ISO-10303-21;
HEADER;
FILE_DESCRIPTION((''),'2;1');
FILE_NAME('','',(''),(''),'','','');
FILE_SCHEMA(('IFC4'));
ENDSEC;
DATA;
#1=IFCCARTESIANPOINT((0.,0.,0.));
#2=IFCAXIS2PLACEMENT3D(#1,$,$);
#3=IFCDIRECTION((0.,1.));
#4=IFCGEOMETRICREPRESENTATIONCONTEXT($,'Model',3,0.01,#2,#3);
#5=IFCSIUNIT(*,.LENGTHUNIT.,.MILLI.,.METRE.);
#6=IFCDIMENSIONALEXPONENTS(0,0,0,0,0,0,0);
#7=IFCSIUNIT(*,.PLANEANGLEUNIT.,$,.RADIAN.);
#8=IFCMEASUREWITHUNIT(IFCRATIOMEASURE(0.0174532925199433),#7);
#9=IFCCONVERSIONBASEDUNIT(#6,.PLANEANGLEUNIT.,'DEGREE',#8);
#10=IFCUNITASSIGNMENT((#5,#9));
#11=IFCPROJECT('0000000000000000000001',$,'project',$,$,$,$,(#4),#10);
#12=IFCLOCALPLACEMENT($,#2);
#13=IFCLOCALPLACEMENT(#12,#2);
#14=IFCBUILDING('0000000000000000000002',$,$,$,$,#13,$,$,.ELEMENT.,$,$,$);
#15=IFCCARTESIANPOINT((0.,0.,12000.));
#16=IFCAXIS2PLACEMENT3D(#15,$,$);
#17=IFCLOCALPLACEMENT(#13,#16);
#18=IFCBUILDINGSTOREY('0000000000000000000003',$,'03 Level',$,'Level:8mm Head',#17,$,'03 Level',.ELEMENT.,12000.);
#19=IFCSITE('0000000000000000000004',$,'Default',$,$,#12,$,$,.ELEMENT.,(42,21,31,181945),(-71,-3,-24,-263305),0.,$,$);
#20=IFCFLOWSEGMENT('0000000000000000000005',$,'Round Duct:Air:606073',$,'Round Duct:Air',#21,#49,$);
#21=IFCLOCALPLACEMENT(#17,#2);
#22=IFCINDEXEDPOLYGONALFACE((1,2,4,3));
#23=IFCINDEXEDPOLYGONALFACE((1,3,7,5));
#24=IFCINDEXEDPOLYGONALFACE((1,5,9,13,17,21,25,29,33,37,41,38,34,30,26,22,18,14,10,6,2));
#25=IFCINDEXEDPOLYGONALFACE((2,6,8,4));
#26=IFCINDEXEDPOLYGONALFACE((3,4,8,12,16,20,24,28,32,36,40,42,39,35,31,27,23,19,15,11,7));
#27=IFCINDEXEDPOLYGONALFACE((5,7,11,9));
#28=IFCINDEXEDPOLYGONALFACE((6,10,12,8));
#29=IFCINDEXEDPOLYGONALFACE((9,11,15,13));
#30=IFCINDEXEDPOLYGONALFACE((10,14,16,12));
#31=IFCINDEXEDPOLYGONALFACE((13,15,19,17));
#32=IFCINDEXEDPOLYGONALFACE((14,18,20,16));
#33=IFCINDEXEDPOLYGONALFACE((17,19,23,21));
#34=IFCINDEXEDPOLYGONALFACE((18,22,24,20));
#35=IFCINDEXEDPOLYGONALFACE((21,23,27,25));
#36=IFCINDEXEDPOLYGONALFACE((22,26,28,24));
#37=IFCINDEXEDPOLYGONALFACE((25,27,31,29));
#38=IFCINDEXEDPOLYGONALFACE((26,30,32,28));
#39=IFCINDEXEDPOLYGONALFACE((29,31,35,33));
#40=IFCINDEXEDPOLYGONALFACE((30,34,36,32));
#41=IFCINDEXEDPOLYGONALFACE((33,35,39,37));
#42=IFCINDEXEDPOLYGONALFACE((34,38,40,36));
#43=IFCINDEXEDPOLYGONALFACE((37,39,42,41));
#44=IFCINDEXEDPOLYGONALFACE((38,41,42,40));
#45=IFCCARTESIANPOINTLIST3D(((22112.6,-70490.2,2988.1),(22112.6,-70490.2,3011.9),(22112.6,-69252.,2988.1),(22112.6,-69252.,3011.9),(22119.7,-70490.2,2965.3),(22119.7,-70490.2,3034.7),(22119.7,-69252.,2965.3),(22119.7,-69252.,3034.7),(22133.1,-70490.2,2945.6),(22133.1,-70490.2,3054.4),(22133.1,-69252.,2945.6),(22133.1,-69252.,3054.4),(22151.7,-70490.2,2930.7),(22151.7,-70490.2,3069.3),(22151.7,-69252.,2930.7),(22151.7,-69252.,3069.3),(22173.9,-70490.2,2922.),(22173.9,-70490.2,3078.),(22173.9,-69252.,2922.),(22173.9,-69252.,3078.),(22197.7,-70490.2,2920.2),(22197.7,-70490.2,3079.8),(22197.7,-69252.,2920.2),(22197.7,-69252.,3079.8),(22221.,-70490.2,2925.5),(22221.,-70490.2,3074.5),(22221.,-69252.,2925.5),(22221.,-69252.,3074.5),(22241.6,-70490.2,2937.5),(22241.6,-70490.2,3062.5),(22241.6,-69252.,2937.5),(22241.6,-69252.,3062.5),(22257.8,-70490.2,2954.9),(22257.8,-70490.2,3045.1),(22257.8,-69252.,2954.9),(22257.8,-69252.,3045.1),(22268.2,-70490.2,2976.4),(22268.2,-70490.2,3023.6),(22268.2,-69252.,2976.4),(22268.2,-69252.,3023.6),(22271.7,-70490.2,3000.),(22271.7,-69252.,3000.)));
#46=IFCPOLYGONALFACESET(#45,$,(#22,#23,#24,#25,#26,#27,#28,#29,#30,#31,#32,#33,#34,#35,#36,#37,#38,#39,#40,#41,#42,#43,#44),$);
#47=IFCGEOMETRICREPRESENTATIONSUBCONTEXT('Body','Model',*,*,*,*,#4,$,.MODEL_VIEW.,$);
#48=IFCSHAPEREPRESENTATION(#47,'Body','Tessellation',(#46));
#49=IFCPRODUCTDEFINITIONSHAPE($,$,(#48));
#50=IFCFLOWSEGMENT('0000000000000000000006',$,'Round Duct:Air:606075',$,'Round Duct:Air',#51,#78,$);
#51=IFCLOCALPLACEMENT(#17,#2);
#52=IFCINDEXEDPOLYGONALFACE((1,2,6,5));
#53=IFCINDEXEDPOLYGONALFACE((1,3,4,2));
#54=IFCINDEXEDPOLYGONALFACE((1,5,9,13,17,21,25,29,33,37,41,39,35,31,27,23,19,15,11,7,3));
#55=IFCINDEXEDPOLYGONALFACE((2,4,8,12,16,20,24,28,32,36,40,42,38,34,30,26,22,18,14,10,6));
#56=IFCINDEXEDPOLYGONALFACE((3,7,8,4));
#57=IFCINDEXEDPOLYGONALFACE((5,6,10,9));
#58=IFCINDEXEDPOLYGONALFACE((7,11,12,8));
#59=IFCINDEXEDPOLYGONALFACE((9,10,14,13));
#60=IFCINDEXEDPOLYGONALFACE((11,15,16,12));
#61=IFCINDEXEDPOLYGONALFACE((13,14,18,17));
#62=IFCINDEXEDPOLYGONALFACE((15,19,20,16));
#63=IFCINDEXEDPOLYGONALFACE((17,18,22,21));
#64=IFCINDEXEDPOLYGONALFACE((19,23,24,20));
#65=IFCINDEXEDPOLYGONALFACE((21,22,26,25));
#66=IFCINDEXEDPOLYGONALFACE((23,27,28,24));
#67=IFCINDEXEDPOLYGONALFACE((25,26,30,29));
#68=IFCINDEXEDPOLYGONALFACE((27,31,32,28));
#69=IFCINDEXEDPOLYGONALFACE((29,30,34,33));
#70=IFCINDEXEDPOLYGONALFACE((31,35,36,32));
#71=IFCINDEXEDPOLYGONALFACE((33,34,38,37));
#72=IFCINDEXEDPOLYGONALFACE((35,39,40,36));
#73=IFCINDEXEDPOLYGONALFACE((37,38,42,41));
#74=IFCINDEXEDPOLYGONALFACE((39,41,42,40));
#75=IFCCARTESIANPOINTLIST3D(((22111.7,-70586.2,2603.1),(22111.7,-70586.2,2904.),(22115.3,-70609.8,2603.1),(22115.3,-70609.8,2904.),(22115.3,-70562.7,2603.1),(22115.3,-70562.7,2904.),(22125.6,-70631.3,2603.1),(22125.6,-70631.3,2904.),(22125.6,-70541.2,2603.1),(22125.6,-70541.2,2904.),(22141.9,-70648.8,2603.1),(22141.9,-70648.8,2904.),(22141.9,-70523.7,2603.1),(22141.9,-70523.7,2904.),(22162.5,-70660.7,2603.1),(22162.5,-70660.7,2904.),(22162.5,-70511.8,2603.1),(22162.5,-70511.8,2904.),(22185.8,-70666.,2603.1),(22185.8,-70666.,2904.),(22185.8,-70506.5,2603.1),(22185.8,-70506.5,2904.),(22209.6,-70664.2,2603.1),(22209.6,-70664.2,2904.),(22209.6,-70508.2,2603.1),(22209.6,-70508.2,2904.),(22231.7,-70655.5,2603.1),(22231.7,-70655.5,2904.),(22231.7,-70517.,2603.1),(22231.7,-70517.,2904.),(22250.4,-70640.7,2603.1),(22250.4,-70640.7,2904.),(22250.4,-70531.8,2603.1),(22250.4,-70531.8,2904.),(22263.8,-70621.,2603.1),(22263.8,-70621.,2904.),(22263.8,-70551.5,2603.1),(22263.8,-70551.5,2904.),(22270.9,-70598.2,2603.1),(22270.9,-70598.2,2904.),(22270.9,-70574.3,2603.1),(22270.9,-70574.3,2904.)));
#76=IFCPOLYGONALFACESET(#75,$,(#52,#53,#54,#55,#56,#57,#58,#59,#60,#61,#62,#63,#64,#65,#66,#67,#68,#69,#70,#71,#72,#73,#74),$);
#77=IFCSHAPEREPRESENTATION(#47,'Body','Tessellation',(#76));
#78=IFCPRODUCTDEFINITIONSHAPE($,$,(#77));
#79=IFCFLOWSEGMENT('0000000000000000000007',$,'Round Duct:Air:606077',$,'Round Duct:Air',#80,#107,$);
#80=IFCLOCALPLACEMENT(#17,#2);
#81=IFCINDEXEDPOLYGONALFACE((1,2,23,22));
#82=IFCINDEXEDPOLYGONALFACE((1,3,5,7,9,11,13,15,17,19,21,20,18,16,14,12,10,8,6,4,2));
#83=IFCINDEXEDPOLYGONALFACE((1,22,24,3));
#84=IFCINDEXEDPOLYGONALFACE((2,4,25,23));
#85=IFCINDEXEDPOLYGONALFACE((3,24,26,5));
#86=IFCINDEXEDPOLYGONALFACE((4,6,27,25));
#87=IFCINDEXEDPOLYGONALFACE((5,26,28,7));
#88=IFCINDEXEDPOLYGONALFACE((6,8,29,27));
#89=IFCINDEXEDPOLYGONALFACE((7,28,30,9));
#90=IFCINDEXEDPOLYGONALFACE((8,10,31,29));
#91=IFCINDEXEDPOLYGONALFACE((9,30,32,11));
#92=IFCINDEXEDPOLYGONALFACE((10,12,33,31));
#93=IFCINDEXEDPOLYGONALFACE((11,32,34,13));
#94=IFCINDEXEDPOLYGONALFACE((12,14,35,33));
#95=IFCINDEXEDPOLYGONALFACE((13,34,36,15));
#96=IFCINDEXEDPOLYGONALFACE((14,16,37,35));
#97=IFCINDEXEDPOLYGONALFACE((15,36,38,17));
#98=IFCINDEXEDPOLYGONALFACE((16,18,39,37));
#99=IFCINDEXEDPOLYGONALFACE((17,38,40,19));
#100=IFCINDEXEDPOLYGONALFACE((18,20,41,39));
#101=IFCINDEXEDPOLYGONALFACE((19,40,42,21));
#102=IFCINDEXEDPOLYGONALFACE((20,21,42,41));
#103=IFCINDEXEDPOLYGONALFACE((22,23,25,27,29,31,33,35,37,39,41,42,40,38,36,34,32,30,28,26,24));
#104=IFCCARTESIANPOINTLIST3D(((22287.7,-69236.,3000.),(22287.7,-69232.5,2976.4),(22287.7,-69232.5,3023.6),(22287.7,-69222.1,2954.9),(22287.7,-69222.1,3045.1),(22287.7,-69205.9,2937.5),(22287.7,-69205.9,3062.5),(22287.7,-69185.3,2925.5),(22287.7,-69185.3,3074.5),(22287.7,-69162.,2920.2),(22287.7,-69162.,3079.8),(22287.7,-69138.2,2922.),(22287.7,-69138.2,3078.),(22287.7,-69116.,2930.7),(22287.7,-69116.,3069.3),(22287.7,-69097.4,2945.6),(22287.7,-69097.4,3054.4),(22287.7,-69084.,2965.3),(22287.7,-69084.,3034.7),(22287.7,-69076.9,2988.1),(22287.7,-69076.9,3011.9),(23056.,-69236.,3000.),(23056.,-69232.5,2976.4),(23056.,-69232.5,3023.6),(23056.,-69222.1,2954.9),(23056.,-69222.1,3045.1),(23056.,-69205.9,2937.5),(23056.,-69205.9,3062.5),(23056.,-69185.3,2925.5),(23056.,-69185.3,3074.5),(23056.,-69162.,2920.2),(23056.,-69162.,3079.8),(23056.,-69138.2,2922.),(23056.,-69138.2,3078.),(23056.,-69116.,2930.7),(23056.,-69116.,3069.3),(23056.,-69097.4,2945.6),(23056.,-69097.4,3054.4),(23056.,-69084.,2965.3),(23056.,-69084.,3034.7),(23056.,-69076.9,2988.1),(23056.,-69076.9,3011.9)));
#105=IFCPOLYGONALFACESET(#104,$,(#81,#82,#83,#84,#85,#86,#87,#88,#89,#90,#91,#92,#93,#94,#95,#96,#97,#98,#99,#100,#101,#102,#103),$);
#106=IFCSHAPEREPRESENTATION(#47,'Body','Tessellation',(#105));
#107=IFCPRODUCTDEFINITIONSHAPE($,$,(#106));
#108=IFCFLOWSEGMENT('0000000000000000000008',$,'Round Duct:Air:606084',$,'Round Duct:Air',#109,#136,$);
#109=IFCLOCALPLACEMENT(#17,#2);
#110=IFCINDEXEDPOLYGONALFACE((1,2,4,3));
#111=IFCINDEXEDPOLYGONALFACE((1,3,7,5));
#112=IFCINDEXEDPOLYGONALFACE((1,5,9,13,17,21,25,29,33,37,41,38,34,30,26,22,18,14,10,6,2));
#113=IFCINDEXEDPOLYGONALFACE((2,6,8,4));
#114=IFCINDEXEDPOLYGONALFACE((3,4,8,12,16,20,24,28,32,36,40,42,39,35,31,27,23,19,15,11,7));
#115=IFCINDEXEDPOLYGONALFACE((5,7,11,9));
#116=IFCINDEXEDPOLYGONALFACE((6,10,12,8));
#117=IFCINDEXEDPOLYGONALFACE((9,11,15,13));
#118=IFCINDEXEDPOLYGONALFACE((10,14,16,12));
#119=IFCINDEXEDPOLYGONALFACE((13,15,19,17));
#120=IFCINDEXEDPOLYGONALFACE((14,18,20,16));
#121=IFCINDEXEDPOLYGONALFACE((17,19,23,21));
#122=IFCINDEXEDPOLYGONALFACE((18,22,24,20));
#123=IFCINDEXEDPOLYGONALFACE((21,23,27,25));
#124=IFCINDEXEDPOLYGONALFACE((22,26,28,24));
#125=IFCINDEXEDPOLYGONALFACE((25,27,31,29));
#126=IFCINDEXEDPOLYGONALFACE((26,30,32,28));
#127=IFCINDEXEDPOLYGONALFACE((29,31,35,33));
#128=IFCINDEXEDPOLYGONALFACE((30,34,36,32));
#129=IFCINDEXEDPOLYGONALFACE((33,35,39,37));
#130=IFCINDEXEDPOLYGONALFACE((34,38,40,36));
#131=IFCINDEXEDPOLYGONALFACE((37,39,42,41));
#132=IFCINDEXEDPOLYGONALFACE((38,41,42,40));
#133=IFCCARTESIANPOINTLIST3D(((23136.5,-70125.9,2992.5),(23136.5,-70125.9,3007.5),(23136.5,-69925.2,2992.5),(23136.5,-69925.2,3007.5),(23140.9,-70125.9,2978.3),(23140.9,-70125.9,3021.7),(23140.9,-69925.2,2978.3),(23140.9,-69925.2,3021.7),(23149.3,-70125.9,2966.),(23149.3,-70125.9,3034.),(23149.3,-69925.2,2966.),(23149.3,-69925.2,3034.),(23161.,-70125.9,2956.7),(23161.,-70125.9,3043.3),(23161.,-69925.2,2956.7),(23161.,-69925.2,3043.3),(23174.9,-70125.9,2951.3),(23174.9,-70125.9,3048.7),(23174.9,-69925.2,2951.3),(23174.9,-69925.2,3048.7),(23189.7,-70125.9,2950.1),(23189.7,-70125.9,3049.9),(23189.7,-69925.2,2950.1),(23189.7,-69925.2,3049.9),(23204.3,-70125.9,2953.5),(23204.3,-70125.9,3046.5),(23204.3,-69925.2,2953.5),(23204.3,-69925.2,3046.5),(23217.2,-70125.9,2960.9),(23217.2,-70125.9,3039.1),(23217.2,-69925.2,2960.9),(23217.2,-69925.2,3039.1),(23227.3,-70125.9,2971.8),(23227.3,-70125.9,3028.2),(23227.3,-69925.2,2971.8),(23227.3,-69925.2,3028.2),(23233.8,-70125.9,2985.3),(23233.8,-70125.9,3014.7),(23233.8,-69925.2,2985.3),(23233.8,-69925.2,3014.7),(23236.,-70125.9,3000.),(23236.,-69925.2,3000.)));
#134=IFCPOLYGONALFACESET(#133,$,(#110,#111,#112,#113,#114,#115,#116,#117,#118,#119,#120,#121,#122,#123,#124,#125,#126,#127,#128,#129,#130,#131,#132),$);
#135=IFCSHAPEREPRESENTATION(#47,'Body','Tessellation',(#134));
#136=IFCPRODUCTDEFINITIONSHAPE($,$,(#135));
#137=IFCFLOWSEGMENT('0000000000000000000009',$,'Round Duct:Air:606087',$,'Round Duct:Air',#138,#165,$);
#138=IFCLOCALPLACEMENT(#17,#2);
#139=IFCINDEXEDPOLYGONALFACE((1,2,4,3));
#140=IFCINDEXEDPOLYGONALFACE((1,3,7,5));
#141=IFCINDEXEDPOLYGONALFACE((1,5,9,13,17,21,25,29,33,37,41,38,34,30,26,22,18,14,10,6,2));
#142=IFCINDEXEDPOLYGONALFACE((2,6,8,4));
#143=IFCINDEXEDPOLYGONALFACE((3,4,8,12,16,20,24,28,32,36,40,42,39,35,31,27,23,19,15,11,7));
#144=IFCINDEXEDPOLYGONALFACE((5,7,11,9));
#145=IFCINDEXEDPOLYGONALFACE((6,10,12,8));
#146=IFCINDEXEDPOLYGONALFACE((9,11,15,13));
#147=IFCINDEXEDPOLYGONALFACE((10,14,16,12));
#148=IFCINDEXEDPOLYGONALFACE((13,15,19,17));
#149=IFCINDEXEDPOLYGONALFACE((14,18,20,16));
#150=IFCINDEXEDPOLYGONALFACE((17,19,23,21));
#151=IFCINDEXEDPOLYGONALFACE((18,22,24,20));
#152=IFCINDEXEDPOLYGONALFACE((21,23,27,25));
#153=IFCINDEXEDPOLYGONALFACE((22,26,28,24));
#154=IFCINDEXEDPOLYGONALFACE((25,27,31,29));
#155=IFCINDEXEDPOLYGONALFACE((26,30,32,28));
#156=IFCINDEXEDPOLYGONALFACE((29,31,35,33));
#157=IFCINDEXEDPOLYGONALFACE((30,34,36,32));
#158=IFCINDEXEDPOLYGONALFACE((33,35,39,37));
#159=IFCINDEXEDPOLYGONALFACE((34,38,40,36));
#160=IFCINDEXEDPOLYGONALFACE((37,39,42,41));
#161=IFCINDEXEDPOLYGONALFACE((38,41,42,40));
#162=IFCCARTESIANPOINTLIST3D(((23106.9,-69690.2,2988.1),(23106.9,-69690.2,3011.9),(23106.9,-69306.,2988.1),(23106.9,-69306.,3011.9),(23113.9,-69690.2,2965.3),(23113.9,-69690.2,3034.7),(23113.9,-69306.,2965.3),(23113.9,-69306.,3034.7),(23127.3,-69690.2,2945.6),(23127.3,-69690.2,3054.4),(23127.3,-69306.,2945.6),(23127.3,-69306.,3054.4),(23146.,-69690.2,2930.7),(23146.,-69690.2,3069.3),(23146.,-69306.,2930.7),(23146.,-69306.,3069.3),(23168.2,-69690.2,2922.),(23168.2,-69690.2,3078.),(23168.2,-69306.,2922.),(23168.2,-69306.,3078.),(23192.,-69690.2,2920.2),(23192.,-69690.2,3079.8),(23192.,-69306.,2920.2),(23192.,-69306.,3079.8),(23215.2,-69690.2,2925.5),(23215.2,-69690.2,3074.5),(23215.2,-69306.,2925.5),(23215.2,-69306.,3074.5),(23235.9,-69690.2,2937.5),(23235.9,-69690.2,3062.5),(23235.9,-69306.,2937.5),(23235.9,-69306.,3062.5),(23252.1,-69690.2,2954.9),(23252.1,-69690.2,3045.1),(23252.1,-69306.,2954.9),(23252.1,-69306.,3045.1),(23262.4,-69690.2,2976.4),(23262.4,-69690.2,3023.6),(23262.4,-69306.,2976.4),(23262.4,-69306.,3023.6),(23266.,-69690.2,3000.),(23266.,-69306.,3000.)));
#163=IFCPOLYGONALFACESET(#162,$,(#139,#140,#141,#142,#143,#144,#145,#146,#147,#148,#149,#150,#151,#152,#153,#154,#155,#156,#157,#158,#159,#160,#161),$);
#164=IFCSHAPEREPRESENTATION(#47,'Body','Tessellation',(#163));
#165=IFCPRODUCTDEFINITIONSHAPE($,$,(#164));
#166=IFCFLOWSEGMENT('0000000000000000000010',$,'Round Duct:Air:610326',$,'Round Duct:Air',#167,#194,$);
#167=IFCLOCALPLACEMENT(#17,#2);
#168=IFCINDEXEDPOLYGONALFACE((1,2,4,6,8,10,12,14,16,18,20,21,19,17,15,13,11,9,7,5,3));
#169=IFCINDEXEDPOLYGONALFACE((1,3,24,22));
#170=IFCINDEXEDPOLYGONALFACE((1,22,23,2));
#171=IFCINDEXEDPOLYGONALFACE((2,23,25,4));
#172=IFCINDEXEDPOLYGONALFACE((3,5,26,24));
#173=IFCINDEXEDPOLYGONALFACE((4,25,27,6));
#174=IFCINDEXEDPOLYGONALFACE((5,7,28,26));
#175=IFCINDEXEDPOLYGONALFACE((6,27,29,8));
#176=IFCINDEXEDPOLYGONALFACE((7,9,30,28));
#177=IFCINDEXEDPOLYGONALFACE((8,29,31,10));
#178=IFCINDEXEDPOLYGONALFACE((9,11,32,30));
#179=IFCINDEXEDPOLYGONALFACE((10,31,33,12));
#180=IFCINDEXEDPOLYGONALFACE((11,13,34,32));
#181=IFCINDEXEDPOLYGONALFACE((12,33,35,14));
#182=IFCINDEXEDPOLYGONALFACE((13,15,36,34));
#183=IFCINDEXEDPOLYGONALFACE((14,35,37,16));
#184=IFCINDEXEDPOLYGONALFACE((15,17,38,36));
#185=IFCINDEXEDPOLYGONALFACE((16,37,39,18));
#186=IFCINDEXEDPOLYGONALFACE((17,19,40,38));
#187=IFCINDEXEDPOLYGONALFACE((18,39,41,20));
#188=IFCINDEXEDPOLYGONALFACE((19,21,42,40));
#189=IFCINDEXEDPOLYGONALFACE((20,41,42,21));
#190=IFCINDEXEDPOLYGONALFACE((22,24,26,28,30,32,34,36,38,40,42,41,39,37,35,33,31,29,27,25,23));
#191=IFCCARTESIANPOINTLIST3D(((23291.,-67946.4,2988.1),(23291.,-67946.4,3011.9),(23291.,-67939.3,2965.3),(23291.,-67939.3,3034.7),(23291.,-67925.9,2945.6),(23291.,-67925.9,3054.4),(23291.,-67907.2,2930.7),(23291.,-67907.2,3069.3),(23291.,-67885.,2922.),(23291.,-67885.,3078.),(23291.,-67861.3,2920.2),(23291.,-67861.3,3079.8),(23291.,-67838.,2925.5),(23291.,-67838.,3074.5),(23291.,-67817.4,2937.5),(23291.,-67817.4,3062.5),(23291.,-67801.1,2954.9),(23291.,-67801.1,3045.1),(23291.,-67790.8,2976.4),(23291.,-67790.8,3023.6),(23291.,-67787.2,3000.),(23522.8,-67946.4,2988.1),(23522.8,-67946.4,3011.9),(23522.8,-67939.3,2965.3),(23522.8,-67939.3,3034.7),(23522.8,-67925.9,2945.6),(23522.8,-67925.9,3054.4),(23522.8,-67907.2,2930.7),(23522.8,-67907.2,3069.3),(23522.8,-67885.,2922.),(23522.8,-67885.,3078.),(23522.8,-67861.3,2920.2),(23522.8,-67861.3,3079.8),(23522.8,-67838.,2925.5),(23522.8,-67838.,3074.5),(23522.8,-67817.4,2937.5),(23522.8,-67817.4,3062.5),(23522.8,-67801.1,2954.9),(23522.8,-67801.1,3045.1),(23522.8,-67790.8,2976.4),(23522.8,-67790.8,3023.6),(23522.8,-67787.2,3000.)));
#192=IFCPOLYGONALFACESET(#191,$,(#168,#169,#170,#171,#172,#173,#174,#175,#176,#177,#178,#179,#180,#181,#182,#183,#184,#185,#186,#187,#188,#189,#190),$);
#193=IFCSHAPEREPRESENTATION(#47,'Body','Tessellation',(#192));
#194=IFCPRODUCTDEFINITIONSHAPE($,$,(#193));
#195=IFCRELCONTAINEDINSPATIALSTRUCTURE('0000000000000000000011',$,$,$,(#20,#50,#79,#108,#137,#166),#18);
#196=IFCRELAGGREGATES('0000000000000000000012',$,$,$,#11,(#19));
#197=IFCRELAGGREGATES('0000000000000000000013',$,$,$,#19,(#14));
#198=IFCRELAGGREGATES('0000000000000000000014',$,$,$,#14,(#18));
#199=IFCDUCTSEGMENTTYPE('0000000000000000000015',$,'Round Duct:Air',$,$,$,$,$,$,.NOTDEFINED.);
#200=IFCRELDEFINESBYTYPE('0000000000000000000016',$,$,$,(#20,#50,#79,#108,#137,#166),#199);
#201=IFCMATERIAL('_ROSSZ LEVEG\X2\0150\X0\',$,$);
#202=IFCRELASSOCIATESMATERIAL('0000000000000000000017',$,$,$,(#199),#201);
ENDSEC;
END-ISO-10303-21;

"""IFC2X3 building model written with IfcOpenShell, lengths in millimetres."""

from ifc_helpers import new_model, entity, si_unit, converted_unit, direction, frame, origin, origin_2d_with_axis, place, context, subcontext, project, spatial, circle, extrude, material, type_object, element, save


model = new_model("IFC2X3")

# Units and contexts
model_context = context("Model", 3, precision=0.01, world=origin(), true_north=direction((0.0, 1.0)))
body_context = subcontext(model_context, "Body", "Model", "MODEL_VIEW")
ifc_project = project(units=[si_unit("LENGTHUNIT", "METRE", prefix="MILLI"), converted_unit("PLANEANGLEUNIT", "DEGREE", entity("IfcRatioMeasure", 0.0174532925199433), si_unit("PLANEANGLEUNIT", "RADIAN"), dimensions=[0, 0, 0, 0, 0, 0, 0])], contexts=[model_context])

# Site, building, storey
site_placement = place(None, origin())
site = spatial("IfcSite", under=ifc_project, at=site_placement, Name="Default", CompositionType="ELEMENT", RefLatitude=(42, 21, 31, 181945), RefLongitude=(-71, -3, -24, -263305), RefElevation=0.0)
building_placement = place(site_placement, origin())
building = spatial("IfcBuilding", under=site, at=building_placement, CompositionType="ELEMENT")
storey_placement = place(building_placement, frame((0.0, 0.0, 12000.0)))
storey = spatial("IfcBuildingStorey", under=building, at=storey_placement, Name="03 Level", ObjectType="Level:8mm Head", LongName="03 Level", CompositionType="ELEMENT", Elevation=12000.0)

# Flow segments
ifc_material = material(Name="_ROSSZ LEVEGŐ")
duct_segment_type_1 = type_object("IfcDuctSegmentType", Name="Round Duct:Air", PredefinedType="NOTDEFINED", material=ifc_material)
flow_segment_1_placement = place(storey_placement, origin())
element("IfcFlowSegment", 1, at=flow_segment_1_placement, inside=storey, type_object=duct_segment_type_1, Name="Round Duct:Air:606073", ObjectType="Round Duct:Air", context=body_context, shape_type="SweptSolid", body=[
    extrude(circle(Radius=80.0, at=origin_2d_with_axis()), frame((22191.7, -70490.2, 3000.0), z_axis=(0.0, 1.0, 0.0), x_axis=(1.0, 0.0, 0.0)), (0.0, 0.0, 1.0), 1238.2),
])
flow_segment_2_placement = place(storey_placement, origin())
element("IfcFlowSegment", 2, at=flow_segment_2_placement, inside=storey, type_object=duct_segment_type_1, Name="Round Duct:Air:606075", ObjectType="Round Duct:Air", context=body_context, shape_type="SweptSolid", body=[
    extrude(circle(Radius=80.0, at=origin_2d_with_axis()), frame((22191.7, -70586.2, 2603.1), z_axis=(0.0, 0.0, 1.0), x_axis=(-1.0, 0.0, 0.0)), (0.0, 0.0, 1.0), 300.9),
])
flow_segment_3_placement = place(storey_placement, origin())
element("IfcFlowSegment", 3, at=flow_segment_3_placement, inside=storey, type_object=duct_segment_type_1, Name="Round Duct:Air:606077", ObjectType="Round Duct:Air", context=body_context, shape_type="SweptSolid", body=[
    extrude(circle(Radius=80.0, at=origin_2d_with_axis()), frame((22287.7, -69156.0, 3000.0), z_axis=(1.0, 0.0, 0.0), x_axis=(0.0, -1.0, 0.0)), (0.0, 0.0, 1.0), 768.2),
])
flow_segment_4_placement = place(storey_placement, origin())
element("IfcFlowSegment", 4, at=flow_segment_4_placement, inside=storey, type_object=duct_segment_type_1, Name="Round Duct:Air:606084", ObjectType="Round Duct:Air", context=body_context, shape_type="SweptSolid", body=[
    extrude(circle(Radius=50.0, at=origin_2d_with_axis()), frame((23186.0, -70125.9, 3000.0), z_axis=(0.0, 1.0, 0.0), x_axis=(1.0, 0.0, 0.0)), (0.0, 0.0, 1.0), 200.7),
])
flow_segment_5_placement = place(storey_placement, origin())
element("IfcFlowSegment", 5, at=flow_segment_5_placement, inside=storey, type_object=duct_segment_type_1, Name="Round Duct:Air:606087", ObjectType="Round Duct:Air", context=body_context, shape_type="SweptSolid", body=[
    extrude(circle(Radius=80.0, at=origin_2d_with_axis()), frame((23186.0, -69690.2, 3000.0), z_axis=(0.0, 1.0, 0.0), x_axis=(1.0, 0.0, 0.0)), (0.0, 0.0, 1.0), 384.2),
])
flow_segment_6_placement = place(storey_placement, origin())
element("IfcFlowSegment", 6, at=flow_segment_6_placement, inside=storey, type_object=duct_segment_type_1, Name="Round Duct:Air:610326", ObjectType="Round Duct:Air", context=body_context, shape_type="SweptSolid", body=[
    extrude(circle(Radius=80.0, at=origin_2d_with_axis()), frame((23291.0, -67867.2, 3000.0), z_axis=(1.0, 0.0, 0.0), x_axis=(0.0, 1.0, 0.0)), (0.0, 0.0, 1.0), 231.8),
])

save(model, "model.ifc")
